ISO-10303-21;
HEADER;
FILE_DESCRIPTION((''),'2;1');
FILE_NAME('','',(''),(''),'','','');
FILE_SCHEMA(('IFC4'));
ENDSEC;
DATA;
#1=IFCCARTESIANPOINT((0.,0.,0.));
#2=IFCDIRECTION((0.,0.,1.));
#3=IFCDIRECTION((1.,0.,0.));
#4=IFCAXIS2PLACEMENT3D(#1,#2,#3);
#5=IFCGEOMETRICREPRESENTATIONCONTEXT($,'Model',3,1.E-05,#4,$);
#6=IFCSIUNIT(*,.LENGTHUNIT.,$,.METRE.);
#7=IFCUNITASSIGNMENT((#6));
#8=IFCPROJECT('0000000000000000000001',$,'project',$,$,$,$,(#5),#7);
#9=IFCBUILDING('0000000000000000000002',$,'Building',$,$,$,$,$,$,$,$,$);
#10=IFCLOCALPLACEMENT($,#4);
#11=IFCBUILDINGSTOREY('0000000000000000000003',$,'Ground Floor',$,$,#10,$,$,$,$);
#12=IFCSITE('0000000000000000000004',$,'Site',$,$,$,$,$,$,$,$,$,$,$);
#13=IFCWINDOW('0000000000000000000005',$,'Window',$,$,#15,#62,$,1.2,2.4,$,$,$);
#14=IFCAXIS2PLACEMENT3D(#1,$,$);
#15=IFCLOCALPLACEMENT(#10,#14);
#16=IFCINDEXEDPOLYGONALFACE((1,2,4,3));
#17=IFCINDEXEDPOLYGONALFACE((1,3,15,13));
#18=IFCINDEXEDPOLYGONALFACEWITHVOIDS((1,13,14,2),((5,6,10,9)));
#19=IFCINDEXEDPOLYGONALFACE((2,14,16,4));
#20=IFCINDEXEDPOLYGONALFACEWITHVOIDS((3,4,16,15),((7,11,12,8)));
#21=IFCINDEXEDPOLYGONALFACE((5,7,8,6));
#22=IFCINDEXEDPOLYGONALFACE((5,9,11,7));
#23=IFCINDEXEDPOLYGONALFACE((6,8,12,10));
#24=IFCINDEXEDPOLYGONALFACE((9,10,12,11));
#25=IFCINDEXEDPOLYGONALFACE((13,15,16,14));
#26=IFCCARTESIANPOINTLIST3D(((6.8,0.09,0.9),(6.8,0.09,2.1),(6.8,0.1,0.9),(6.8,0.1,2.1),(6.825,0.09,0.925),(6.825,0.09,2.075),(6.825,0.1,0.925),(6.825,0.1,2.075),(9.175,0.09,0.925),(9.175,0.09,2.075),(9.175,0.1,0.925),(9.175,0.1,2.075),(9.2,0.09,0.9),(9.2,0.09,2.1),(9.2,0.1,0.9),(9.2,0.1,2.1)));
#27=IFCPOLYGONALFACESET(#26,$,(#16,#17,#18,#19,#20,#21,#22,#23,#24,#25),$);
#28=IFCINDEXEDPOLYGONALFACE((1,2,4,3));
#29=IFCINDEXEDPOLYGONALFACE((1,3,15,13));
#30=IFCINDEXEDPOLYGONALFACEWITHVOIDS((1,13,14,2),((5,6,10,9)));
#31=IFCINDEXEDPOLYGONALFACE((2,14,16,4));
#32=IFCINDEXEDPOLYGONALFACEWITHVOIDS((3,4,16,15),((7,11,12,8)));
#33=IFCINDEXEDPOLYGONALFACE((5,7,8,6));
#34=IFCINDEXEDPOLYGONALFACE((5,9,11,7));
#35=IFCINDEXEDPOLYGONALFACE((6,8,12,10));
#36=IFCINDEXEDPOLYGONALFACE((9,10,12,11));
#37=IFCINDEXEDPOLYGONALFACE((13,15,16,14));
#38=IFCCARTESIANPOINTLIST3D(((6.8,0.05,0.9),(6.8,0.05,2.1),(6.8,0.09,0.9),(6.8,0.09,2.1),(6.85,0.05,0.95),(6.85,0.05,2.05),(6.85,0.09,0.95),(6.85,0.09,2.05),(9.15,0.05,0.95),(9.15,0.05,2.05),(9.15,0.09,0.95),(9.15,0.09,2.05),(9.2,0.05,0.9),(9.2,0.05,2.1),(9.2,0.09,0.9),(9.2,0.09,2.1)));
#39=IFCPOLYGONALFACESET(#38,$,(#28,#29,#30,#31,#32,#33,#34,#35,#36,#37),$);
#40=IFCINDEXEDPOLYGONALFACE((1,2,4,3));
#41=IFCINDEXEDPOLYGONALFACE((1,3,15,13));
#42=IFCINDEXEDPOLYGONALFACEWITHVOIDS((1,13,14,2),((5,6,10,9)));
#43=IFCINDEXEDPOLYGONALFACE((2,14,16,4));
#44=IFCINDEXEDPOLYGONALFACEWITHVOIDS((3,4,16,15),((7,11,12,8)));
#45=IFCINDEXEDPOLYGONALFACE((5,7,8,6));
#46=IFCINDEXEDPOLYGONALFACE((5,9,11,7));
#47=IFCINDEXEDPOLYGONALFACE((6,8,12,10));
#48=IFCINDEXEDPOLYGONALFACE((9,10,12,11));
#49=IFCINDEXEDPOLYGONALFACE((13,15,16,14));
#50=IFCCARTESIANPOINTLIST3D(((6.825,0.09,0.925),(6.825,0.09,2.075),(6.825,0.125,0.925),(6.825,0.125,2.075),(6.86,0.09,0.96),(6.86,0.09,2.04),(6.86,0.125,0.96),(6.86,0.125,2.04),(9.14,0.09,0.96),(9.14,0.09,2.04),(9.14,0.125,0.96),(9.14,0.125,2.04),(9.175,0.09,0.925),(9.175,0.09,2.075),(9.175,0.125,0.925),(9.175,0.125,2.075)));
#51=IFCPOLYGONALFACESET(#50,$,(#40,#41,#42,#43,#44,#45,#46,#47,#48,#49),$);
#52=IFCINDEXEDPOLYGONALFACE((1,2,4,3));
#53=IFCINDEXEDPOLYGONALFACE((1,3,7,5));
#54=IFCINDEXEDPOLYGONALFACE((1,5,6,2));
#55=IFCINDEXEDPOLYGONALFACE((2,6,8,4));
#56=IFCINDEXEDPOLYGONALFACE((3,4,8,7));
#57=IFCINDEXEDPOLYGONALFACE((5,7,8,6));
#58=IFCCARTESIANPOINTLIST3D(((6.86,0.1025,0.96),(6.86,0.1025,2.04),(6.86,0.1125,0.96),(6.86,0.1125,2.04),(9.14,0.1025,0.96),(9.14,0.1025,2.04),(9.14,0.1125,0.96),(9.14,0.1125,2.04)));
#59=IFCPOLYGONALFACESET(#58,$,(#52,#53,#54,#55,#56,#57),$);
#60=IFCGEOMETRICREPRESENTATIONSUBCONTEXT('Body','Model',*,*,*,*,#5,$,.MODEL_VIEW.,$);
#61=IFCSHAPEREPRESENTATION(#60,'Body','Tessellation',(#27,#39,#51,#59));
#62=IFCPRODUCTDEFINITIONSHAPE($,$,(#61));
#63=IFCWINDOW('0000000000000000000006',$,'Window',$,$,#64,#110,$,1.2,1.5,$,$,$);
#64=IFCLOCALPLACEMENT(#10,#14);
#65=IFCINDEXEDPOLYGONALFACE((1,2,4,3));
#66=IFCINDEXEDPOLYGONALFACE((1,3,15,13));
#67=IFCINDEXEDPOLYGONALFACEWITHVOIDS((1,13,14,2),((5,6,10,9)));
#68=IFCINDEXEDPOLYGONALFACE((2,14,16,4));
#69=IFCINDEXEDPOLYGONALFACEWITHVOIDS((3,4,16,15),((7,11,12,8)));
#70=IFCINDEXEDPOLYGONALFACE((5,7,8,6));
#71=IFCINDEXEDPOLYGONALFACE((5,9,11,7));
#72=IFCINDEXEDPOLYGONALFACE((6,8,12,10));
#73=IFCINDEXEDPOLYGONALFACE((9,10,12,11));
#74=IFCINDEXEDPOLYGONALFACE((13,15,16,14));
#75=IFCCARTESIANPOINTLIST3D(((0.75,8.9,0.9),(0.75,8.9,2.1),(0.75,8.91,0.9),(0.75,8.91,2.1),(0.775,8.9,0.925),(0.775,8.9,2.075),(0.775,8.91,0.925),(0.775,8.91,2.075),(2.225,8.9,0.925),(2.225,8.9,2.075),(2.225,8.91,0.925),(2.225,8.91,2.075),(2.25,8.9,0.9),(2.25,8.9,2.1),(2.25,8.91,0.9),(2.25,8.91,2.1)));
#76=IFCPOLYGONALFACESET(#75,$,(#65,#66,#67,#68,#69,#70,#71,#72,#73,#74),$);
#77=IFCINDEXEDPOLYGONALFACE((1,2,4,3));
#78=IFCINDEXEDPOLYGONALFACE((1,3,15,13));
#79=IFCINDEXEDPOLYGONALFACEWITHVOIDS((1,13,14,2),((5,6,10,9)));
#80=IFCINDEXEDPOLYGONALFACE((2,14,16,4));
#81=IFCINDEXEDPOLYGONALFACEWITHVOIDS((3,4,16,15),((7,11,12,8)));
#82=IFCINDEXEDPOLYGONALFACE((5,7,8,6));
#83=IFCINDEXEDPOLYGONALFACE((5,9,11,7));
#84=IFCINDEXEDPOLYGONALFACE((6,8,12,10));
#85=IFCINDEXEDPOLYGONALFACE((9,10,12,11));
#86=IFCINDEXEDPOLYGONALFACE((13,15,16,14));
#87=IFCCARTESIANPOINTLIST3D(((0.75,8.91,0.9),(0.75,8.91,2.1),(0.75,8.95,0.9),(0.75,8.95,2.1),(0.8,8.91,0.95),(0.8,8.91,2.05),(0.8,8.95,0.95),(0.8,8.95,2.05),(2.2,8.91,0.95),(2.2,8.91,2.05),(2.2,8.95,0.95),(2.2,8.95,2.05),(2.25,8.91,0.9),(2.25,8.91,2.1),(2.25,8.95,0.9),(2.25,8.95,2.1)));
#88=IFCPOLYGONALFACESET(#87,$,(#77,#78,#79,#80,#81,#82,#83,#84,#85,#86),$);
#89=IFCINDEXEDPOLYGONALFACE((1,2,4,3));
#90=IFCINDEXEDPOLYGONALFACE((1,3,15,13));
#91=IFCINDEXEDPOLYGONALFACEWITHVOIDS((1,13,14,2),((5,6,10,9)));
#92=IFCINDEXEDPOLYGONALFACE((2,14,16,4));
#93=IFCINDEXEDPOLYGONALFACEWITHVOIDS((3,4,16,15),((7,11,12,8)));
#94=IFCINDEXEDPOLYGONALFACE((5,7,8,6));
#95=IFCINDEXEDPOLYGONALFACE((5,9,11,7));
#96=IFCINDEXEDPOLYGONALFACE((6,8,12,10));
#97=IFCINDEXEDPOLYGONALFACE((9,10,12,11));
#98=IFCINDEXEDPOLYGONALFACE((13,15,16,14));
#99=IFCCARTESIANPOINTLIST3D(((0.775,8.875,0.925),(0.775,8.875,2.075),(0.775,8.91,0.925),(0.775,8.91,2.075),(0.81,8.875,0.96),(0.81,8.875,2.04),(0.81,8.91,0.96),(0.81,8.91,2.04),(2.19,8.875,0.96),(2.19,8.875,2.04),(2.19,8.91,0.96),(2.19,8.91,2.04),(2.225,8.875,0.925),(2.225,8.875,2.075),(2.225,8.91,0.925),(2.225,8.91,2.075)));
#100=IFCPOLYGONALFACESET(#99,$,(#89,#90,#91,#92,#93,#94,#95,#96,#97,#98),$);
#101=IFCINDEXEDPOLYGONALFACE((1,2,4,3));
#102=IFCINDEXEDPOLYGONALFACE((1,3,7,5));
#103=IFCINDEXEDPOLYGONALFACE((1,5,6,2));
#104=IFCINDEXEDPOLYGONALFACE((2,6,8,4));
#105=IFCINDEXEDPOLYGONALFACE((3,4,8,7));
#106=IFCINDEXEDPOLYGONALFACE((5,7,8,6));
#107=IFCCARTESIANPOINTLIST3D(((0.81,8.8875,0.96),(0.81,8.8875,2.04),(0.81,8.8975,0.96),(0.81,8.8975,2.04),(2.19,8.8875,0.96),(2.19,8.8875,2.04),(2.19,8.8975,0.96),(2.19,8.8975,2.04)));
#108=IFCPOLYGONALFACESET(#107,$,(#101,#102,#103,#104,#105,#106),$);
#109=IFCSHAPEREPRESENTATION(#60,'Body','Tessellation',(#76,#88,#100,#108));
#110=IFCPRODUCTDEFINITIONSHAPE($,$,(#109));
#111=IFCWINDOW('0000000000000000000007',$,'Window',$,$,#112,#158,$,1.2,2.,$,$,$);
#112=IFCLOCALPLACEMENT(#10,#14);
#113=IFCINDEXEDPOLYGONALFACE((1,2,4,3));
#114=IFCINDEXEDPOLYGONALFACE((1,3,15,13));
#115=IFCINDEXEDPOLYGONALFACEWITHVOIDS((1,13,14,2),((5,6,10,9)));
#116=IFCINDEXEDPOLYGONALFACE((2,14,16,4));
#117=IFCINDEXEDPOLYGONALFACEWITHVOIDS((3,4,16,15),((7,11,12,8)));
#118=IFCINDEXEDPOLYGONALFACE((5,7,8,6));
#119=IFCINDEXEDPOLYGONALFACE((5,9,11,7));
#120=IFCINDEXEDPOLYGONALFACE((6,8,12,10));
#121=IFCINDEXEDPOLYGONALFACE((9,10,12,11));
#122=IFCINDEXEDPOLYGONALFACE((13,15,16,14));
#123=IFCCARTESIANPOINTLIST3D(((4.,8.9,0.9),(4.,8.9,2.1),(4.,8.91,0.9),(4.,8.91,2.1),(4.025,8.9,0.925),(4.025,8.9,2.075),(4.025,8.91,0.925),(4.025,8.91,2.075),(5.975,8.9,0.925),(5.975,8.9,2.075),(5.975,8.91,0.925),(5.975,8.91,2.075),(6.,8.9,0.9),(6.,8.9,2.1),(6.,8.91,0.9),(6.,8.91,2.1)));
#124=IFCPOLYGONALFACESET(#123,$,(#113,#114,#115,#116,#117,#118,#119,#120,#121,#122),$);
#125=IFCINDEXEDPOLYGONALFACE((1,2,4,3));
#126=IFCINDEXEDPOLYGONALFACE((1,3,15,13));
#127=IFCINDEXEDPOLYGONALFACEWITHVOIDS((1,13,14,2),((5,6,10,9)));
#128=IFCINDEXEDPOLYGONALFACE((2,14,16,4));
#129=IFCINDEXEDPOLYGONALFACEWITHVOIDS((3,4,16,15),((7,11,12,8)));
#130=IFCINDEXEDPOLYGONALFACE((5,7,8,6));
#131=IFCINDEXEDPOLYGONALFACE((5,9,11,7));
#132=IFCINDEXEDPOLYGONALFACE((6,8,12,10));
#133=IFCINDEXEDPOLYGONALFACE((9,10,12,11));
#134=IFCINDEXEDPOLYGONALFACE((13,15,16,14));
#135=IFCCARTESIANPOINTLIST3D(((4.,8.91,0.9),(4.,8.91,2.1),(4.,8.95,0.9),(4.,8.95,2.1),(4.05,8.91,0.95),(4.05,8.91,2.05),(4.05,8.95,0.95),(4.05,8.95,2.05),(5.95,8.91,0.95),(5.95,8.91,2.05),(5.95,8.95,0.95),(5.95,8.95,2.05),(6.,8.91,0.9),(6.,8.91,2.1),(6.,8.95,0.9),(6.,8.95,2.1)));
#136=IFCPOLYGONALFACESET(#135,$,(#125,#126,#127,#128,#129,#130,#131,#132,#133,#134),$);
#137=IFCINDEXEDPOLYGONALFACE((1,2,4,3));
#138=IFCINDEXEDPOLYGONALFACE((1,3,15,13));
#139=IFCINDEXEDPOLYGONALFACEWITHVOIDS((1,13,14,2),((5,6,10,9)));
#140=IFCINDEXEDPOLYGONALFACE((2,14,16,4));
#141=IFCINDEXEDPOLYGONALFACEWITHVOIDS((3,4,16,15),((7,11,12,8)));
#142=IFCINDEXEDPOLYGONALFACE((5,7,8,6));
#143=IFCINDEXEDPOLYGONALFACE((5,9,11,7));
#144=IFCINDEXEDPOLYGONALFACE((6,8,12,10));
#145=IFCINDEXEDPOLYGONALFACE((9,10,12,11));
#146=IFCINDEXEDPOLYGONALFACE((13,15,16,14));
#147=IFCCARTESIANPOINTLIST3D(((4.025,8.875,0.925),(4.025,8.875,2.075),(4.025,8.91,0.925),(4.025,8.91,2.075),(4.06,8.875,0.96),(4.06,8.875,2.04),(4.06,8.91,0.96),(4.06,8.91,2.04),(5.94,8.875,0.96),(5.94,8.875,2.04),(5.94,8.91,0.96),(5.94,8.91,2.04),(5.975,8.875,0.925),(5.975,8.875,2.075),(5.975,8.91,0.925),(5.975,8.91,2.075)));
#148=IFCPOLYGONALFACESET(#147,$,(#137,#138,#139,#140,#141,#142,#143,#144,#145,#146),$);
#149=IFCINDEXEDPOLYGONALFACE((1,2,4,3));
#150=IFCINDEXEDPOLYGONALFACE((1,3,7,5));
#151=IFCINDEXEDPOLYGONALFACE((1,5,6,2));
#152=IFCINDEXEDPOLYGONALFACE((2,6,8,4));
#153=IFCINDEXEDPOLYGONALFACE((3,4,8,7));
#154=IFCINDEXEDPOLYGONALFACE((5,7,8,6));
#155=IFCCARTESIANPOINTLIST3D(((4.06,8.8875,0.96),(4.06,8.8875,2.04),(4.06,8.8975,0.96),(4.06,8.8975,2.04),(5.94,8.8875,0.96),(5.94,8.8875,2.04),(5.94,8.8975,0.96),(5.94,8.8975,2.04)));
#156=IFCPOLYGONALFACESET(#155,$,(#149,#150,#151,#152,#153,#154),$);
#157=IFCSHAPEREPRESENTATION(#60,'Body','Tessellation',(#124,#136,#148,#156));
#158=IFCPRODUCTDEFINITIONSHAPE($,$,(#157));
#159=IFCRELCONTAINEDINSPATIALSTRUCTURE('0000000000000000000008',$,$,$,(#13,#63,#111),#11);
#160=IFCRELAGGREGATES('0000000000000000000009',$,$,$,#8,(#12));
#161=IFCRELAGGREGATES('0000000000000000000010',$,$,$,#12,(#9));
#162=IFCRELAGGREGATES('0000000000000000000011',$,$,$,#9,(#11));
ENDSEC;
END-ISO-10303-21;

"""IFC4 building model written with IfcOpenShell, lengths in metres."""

from ifc_helpers import new_model, si_unit, frame, origin_with_axes, place, context, subcontext, project, spatial, line, indexed_curve, outline, extrude, element, save


model = new_model("IFC4")

# Units and contexts
model_context = context("Model", 3, precision=1e-05, world=origin_with_axes())
body_context = subcontext(model_context, "Body", "Model", "MODEL_VIEW")
ifc_project = project(units=[si_unit("LENGTHUNIT", "METRE")], contexts=[model_context])

# Site, building, storey
site = spatial("IfcSite", under=ifc_project, Name="Site")
building = spatial("IfcBuilding", under=site, Name="Building")
storey_placement = place(None, origin_with_axes())
storey = spatial("IfcBuildingStorey", under=building, at=storey_placement, Name="Ground Floor")

# Windows
window_1_placement = place(storey_placement, frame((6.8, 0.0, 0.9), z_axis=(0.0, 0.0, 1.0), x_axis=(1.0, 0.0, 0.0)))
element("IfcWindow", 1, at=window_1_placement, inside=storey, Name="Window", OverallHeight=1.2, OverallWidth=2.4, context=body_context, shape_type="SweptSolid", body=[
    extrude(outline(indexed_curve([(0.0, 0.0), (2.4, 0.0), (2.4, 1.2), (0.0, 1.2)], segments=[line(1, 2, 3, 4, 1)]), holes=[indexed_curve([(0.025, 0.025), (2.375, 0.025), (2.375, 1.175), (0.025, 1.175)], segments=[line(1, 2, 3, 4, 1)])]), frame((0.0, 0.09, 0.0), z_axis=(0.0, -1.0, 0.0), x_axis=(1.0, 0.0, 0.0)), (0.0, 0.0, -1.0), 0.01),
    extrude(outline(indexed_curve([(0.0, 0.0), (2.4, 0.0), (2.4, 1.2), (0.0, 1.2)], segments=[line(1, 2, 3, 4, 1)]), holes=[indexed_curve([(0.05, 0.05), (2.35, 0.05), (2.35, 1.15), (0.05, 1.15)], segments=[line(1, 2, 3, 4, 1)])]), frame((0.0, 0.05, 0.0), z_axis=(0.0, -1.0, 0.0), x_axis=(1.0, 0.0, 0.0)), (0.0, 0.0, -1.0), 0.04),
    extrude(outline(indexed_curve([(0.0, 0.0), (2.35, 0.0), (2.35, 1.15), (0.0, 1.15)], segments=[line(1, 2, 3, 4, 1)]), holes=[indexed_curve([(0.035, 0.035), (2.315, 0.035), (2.315, 1.115), (0.035, 1.115)], segments=[line(1, 2, 3, 4, 1)])]), frame((0.025, 0.09, 0.025), z_axis=(0.0, -1.0, 0.0), x_axis=(1.0, 0.0, 0.0)), (0.0, 0.0, -1.0), 0.035),
    extrude(outline(indexed_curve([(0.035, 0.035), (2.315, 0.035), (2.315, 1.115), (0.035, 1.115)], segments=[line(1, 2, 3, 4, 1)])), frame((0.025, 0.1025, 0.025), z_axis=(0.0, -1.0, 0.0), x_axis=(1.0, 0.0, 0.0)), (0.0, 0.0, -1.0), 0.01),
])
window_2_placement = place(storey_placement, frame((2.25, 9.0, 0.9), z_axis=(0.0, 0.0, 1.0), x_axis=(-1.0, 0.0, 0.0)))
element("IfcWindow", 2, at=window_2_placement, inside=storey, Name="Window", OverallHeight=1.2, OverallWidth=1.5, context=body_context, shape_type="SweptSolid", body=[
    extrude(outline(indexed_curve([(0.0, 0.0), (1.5, 0.0), (1.5, 1.2), (0.0, 1.2)], segments=[line(1, 2, 3, 4, 1)]), holes=[indexed_curve([(0.025, 0.025), (1.475, 0.025), (1.475, 1.175), (0.025, 1.175)], segments=[line(1, 2, 3, 4, 1)])]), frame((0.0, 0.09, 0.0), z_axis=(0.0, -1.0, 0.0), x_axis=(1.0, 0.0, 0.0)), (0.0, 0.0, -1.0), 0.01),
    extrude(outline(indexed_curve([(0.0, 0.0), (1.5, 0.0), (1.5, 1.2), (0.0, 1.2)], segments=[line(1, 2, 3, 4, 1)]), holes=[indexed_curve([(0.05, 0.05), (1.45, 0.05), (1.45, 1.15), (0.05, 1.15)], segments=[line(1, 2, 3, 4, 1)])]), frame((0.0, 0.05, 0.0), z_axis=(0.0, -1.0, 0.0), x_axis=(1.0, 0.0, 0.0)), (0.0, 0.0, -1.0), 0.04),
    extrude(outline(indexed_curve([(0.0, 0.0), (1.45, 0.0), (1.45, 1.15), (0.0, 1.15)], segments=[line(1, 2, 3, 4, 1)]), holes=[indexed_curve([(0.035, 0.035), (1.415, 0.035), (1.415, 1.115), (0.035, 1.115)], segments=[line(1, 2, 3, 4, 1)])]), frame((0.025, 0.09, 0.025), z_axis=(0.0, -1.0, 0.0), x_axis=(1.0, 0.0, 0.0)), (0.0, 0.0, -1.0), 0.035),
    extrude(outline(indexed_curve([(0.035, 0.035), (1.415, 0.035), (1.415, 1.115), (0.035, 1.115)], segments=[line(1, 2, 3, 4, 1)])), frame((0.025, 0.1025, 0.025), z_axis=(0.0, -1.0, 0.0), x_axis=(1.0, 0.0, 0.0)), (0.0, 0.0, -1.0), 0.01),
])
window_3_placement = place(storey_placement, frame((6.0, 9.0, 0.9), z_axis=(0.0, 0.0, 1.0), x_axis=(-1.0, 0.0, 0.0)))
element("IfcWindow", 3, at=window_3_placement, inside=storey, Name="Window", OverallHeight=1.2, OverallWidth=2.0, context=body_context, shape_type="SweptSolid", body=[
    extrude(outline(indexed_curve([(0.0, 0.0), (2.0, 0.0), (2.0, 1.2), (0.0, 1.2)], segments=[line(1, 2, 3, 4, 1)]), holes=[indexed_curve([(0.025, 0.025), (1.975, 0.025), (1.975, 1.175), (0.025, 1.175)], segments=[line(1, 2, 3, 4, 1)])]), frame((0.0, 0.09, 0.0), z_axis=(0.0, -1.0, 0.0), x_axis=(1.0, 0.0, 0.0)), (0.0, 0.0, -1.0), 0.01),
    extrude(outline(indexed_curve([(0.0, 0.0), (2.0, 0.0), (2.0, 1.2), (0.0, 1.2)], segments=[line(1, 2, 3, 4, 1)]), holes=[indexed_curve([(0.05, 0.05), (1.95, 0.05), (1.95, 1.15), (0.05, 1.15)], segments=[line(1, 2, 3, 4, 1)])]), frame((0.0, 0.05, 0.0), z_axis=(0.0, -1.0, 0.0), x_axis=(1.0, 0.0, 0.0)), (0.0, 0.0, -1.0), 0.04),
    extrude(outline(indexed_curve([(0.0, 0.0), (1.95, 0.0), (1.95, 1.15), (0.0, 1.15)], segments=[line(1, 2, 3, 4, 1)]), holes=[indexed_curve([(0.035, 0.035), (1.915, 0.035), (1.915, 1.115), (0.035, 1.115)], segments=[line(1, 2, 3, 4, 1)])]), frame((0.025, 0.09, 0.025), z_axis=(0.0, -1.0, 0.0), x_axis=(1.0, 0.0, 0.0)), (0.0, 0.0, -1.0), 0.035),
    extrude(outline(indexed_curve([(0.035, 0.035), (1.915, 0.035), (1.915, 1.115), (0.035, 1.115)], segments=[line(1, 2, 3, 4, 1)])), frame((0.025, 0.1025, 0.025), z_axis=(0.0, -1.0, 0.0), x_axis=(1.0, 0.0, 0.0)), (0.0, 0.0, -1.0), 0.01),
])

save(model, "model.ifc")
